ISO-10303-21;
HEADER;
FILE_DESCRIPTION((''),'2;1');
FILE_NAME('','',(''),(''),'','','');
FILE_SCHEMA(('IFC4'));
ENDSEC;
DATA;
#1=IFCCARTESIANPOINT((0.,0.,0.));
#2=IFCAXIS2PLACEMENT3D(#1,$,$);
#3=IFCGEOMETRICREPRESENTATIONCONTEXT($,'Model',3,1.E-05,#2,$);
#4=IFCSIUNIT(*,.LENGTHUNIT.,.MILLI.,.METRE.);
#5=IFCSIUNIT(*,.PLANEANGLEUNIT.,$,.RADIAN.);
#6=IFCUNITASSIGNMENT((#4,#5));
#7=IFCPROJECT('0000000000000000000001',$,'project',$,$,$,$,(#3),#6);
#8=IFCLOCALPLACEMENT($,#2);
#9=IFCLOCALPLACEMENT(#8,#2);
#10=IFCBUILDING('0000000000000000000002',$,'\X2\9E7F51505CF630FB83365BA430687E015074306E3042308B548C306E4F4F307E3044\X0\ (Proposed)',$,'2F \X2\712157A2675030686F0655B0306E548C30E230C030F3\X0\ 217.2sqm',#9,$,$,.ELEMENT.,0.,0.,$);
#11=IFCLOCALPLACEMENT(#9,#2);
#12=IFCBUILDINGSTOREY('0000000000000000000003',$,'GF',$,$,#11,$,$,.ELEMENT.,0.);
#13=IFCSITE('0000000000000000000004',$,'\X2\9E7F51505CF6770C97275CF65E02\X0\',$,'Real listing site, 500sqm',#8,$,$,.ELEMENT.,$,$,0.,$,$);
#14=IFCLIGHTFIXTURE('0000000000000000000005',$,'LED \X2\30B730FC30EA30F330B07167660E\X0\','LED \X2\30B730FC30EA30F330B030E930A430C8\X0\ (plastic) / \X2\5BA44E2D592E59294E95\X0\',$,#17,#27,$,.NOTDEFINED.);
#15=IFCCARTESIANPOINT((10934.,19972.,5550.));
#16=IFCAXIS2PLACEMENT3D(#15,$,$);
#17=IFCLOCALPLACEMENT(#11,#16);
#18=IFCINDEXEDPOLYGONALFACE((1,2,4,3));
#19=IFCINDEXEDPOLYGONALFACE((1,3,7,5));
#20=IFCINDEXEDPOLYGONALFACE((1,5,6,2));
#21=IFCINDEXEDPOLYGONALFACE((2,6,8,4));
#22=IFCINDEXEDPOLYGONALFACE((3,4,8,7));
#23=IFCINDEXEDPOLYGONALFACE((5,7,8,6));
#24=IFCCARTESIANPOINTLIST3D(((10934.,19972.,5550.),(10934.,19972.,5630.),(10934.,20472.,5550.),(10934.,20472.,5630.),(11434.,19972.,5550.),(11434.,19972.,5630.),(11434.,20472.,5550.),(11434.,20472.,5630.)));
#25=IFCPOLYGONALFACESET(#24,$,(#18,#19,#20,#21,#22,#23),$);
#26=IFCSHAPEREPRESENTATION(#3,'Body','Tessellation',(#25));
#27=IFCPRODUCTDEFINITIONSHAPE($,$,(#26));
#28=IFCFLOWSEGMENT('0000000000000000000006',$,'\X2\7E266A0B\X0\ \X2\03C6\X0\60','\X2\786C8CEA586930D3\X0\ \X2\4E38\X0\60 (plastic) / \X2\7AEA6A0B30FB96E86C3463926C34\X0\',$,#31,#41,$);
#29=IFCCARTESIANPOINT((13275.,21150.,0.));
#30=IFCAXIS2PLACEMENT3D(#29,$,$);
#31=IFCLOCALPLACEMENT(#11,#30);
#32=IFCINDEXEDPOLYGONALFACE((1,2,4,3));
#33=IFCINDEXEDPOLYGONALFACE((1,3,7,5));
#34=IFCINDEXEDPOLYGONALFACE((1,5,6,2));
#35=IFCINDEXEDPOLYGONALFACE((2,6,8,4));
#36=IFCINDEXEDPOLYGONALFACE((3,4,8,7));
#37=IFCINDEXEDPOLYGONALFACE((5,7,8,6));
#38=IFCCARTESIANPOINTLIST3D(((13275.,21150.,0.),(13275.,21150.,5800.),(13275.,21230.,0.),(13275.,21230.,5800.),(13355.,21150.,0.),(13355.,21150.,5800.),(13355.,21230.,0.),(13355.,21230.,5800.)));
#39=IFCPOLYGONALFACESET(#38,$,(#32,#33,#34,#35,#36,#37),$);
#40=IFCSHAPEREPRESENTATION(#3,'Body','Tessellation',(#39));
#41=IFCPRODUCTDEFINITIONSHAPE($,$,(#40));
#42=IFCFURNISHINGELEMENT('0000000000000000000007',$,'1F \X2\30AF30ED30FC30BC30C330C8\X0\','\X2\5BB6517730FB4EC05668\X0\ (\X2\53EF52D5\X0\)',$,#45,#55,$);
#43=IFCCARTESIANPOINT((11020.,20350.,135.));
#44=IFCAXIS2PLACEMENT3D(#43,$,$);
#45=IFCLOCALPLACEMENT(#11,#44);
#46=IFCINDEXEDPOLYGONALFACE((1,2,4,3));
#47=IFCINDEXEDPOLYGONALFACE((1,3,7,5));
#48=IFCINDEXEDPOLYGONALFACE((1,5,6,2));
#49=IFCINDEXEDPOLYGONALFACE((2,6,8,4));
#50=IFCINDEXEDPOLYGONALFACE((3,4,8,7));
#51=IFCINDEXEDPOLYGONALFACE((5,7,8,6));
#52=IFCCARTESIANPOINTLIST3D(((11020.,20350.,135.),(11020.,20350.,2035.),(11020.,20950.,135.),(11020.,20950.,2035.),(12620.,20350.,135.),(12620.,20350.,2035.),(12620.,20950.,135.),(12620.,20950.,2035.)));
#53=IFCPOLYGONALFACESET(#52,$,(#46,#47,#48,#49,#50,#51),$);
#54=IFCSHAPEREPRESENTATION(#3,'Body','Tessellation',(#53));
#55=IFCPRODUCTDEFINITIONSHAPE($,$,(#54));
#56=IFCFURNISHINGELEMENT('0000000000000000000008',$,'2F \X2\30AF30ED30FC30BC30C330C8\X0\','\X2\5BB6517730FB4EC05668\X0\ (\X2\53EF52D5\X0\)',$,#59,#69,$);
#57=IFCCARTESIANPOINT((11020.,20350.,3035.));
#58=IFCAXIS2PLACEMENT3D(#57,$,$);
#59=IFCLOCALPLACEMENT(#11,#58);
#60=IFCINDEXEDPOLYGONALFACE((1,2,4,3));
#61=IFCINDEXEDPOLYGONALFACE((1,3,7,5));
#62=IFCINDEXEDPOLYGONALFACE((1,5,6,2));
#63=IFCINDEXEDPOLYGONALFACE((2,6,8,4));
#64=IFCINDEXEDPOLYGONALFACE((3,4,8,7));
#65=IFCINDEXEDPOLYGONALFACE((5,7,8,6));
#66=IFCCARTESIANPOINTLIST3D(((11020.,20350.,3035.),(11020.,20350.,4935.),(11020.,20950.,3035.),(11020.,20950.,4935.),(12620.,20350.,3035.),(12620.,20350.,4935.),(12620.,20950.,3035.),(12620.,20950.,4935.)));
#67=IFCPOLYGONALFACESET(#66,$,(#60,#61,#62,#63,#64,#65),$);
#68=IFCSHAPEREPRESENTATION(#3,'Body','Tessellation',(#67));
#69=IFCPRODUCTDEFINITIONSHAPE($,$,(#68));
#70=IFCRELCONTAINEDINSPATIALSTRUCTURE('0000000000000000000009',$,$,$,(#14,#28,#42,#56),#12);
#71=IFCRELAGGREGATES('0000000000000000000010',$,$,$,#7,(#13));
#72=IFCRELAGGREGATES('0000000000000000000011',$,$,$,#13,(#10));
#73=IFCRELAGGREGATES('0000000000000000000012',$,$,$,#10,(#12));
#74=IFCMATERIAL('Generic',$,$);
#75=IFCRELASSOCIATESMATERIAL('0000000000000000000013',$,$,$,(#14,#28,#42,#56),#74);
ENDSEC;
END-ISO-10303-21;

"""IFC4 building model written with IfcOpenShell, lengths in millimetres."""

from ifc_helpers import new_model, si_unit, frame, frame_2d, origin, place, context, project, spatial, rectangle, extrude, material, element, save


model = new_model("IFC4")

# Units and contexts
model_context = context("Model", 3, precision=1e-05, world=origin())
ifc_project = project(units=[si_unit("LENGTHUNIT", "METRE", prefix="MILLI"), si_unit("PLANEANGLEUNIT", "RADIAN")], contexts=[model_context])

# Site, building, storey
site_placement = place(None, origin())
site = spatial("IfcSite", under=ifc_project, at=site_placement, Name="鹿児島県霧島市", ObjectType="Real listing site, 500sqm", CompositionType="ELEMENT", RefElevation=0.0)
building_placement = place(site_placement, origin())
building = spatial("IfcBuilding", under=site, at=building_placement, Name="鹿児島・茶室と縁側のある和の住まい (Proposed)", ObjectType="2F 無垢材と漆喰の和モダン 217.2sqm", CompositionType="ELEMENT", ElevationOfRefHeight=0.0, ElevationOfTerrain=0.0)
storey_placement = place(building_placement, origin())
storey = spatial("IfcBuildingStorey", under=building, at=storey_placement, Name="GF", CompositionType="ELEMENT", Elevation=0.0)

# Shared definitions
ifc_material_1 = material(Name="Generic")

# Light fixture
light_fixture_1_placement = place(storey_placement, frame((10934.0, 19972.0, 5550.0)))
element("IfcLightFixture", 1, at=light_fixture_1_placement, inside=storey, material=ifc_material_1, Name="LED シーリング照明", Description="LED シーリングライト (plastic) / 室中央天井", PredefinedType="NOTDEFINED", context=model_context, shape_type="SweptSolid", body=[
    extrude(rectangle(XDim=500.0, YDim=500.0, at=frame_2d((250.0, 250.0))), frame((10934.0, 19972.0, 5550.0)), (0.0, 0.0, 1.0), 80.0),
])

# Flow segment
flow_segment_placement = place(storey_placement, frame((13275.0, 21150.0, 0.0)))
element("IfcFlowSegment", 2, at=flow_segment_placement, inside=storey, material=ifc_material_1, Name="縦樋 φ60", Description="硬質塩ビ 丸60 (plastic) / 竪樋・雨水排水", context=model_context, shape_type="SweptSolid", body=[
    extrude(rectangle(XDim=80.0, YDim=80.0, at=frame_2d((40.0, 40.0))), frame((13275.0, 21150.0, 0.0)), (0.0, 0.0, 1.0), 5800.0),
])

# Furnishing elements
furnishing_1_placement = place(storey_placement, frame((11020.0, 20350.0, 135.0)))
element("IfcFurnishingElement", 3, at=furnishing_1_placement, inside=storey, material=ifc_material_1, Name="1F クローゼット", Description="家具・什器 (可動)", context=model_context, shape_type="SweptSolid", body=[
    extrude(rectangle(XDim=1600.0, YDim=600.0, at=frame_2d((800.0, 300.0))), frame((11020.0, 20350.0, 135.0)), (0.0, 0.0, 1.0), 1900.0),
])
furnishing_2_placement = place(storey_placement, frame((11020.0, 20350.0, 3035.0)))
element("IfcFurnishingElement", 4, at=furnishing_2_placement, inside=storey, material=ifc_material_1, Name="2F クローゼット", Description="家具・什器 (可動)", context=model_context, shape_type="SweptSolid", body=[
    extrude(rectangle(XDim=1600.0, YDim=600.0, at=frame_2d((800.0, 300.0))), frame((11020.0, 20350.0, 3035.0)), (0.0, 0.0, 1.0), 1900.0),
])

save(model, "model.ifc")
